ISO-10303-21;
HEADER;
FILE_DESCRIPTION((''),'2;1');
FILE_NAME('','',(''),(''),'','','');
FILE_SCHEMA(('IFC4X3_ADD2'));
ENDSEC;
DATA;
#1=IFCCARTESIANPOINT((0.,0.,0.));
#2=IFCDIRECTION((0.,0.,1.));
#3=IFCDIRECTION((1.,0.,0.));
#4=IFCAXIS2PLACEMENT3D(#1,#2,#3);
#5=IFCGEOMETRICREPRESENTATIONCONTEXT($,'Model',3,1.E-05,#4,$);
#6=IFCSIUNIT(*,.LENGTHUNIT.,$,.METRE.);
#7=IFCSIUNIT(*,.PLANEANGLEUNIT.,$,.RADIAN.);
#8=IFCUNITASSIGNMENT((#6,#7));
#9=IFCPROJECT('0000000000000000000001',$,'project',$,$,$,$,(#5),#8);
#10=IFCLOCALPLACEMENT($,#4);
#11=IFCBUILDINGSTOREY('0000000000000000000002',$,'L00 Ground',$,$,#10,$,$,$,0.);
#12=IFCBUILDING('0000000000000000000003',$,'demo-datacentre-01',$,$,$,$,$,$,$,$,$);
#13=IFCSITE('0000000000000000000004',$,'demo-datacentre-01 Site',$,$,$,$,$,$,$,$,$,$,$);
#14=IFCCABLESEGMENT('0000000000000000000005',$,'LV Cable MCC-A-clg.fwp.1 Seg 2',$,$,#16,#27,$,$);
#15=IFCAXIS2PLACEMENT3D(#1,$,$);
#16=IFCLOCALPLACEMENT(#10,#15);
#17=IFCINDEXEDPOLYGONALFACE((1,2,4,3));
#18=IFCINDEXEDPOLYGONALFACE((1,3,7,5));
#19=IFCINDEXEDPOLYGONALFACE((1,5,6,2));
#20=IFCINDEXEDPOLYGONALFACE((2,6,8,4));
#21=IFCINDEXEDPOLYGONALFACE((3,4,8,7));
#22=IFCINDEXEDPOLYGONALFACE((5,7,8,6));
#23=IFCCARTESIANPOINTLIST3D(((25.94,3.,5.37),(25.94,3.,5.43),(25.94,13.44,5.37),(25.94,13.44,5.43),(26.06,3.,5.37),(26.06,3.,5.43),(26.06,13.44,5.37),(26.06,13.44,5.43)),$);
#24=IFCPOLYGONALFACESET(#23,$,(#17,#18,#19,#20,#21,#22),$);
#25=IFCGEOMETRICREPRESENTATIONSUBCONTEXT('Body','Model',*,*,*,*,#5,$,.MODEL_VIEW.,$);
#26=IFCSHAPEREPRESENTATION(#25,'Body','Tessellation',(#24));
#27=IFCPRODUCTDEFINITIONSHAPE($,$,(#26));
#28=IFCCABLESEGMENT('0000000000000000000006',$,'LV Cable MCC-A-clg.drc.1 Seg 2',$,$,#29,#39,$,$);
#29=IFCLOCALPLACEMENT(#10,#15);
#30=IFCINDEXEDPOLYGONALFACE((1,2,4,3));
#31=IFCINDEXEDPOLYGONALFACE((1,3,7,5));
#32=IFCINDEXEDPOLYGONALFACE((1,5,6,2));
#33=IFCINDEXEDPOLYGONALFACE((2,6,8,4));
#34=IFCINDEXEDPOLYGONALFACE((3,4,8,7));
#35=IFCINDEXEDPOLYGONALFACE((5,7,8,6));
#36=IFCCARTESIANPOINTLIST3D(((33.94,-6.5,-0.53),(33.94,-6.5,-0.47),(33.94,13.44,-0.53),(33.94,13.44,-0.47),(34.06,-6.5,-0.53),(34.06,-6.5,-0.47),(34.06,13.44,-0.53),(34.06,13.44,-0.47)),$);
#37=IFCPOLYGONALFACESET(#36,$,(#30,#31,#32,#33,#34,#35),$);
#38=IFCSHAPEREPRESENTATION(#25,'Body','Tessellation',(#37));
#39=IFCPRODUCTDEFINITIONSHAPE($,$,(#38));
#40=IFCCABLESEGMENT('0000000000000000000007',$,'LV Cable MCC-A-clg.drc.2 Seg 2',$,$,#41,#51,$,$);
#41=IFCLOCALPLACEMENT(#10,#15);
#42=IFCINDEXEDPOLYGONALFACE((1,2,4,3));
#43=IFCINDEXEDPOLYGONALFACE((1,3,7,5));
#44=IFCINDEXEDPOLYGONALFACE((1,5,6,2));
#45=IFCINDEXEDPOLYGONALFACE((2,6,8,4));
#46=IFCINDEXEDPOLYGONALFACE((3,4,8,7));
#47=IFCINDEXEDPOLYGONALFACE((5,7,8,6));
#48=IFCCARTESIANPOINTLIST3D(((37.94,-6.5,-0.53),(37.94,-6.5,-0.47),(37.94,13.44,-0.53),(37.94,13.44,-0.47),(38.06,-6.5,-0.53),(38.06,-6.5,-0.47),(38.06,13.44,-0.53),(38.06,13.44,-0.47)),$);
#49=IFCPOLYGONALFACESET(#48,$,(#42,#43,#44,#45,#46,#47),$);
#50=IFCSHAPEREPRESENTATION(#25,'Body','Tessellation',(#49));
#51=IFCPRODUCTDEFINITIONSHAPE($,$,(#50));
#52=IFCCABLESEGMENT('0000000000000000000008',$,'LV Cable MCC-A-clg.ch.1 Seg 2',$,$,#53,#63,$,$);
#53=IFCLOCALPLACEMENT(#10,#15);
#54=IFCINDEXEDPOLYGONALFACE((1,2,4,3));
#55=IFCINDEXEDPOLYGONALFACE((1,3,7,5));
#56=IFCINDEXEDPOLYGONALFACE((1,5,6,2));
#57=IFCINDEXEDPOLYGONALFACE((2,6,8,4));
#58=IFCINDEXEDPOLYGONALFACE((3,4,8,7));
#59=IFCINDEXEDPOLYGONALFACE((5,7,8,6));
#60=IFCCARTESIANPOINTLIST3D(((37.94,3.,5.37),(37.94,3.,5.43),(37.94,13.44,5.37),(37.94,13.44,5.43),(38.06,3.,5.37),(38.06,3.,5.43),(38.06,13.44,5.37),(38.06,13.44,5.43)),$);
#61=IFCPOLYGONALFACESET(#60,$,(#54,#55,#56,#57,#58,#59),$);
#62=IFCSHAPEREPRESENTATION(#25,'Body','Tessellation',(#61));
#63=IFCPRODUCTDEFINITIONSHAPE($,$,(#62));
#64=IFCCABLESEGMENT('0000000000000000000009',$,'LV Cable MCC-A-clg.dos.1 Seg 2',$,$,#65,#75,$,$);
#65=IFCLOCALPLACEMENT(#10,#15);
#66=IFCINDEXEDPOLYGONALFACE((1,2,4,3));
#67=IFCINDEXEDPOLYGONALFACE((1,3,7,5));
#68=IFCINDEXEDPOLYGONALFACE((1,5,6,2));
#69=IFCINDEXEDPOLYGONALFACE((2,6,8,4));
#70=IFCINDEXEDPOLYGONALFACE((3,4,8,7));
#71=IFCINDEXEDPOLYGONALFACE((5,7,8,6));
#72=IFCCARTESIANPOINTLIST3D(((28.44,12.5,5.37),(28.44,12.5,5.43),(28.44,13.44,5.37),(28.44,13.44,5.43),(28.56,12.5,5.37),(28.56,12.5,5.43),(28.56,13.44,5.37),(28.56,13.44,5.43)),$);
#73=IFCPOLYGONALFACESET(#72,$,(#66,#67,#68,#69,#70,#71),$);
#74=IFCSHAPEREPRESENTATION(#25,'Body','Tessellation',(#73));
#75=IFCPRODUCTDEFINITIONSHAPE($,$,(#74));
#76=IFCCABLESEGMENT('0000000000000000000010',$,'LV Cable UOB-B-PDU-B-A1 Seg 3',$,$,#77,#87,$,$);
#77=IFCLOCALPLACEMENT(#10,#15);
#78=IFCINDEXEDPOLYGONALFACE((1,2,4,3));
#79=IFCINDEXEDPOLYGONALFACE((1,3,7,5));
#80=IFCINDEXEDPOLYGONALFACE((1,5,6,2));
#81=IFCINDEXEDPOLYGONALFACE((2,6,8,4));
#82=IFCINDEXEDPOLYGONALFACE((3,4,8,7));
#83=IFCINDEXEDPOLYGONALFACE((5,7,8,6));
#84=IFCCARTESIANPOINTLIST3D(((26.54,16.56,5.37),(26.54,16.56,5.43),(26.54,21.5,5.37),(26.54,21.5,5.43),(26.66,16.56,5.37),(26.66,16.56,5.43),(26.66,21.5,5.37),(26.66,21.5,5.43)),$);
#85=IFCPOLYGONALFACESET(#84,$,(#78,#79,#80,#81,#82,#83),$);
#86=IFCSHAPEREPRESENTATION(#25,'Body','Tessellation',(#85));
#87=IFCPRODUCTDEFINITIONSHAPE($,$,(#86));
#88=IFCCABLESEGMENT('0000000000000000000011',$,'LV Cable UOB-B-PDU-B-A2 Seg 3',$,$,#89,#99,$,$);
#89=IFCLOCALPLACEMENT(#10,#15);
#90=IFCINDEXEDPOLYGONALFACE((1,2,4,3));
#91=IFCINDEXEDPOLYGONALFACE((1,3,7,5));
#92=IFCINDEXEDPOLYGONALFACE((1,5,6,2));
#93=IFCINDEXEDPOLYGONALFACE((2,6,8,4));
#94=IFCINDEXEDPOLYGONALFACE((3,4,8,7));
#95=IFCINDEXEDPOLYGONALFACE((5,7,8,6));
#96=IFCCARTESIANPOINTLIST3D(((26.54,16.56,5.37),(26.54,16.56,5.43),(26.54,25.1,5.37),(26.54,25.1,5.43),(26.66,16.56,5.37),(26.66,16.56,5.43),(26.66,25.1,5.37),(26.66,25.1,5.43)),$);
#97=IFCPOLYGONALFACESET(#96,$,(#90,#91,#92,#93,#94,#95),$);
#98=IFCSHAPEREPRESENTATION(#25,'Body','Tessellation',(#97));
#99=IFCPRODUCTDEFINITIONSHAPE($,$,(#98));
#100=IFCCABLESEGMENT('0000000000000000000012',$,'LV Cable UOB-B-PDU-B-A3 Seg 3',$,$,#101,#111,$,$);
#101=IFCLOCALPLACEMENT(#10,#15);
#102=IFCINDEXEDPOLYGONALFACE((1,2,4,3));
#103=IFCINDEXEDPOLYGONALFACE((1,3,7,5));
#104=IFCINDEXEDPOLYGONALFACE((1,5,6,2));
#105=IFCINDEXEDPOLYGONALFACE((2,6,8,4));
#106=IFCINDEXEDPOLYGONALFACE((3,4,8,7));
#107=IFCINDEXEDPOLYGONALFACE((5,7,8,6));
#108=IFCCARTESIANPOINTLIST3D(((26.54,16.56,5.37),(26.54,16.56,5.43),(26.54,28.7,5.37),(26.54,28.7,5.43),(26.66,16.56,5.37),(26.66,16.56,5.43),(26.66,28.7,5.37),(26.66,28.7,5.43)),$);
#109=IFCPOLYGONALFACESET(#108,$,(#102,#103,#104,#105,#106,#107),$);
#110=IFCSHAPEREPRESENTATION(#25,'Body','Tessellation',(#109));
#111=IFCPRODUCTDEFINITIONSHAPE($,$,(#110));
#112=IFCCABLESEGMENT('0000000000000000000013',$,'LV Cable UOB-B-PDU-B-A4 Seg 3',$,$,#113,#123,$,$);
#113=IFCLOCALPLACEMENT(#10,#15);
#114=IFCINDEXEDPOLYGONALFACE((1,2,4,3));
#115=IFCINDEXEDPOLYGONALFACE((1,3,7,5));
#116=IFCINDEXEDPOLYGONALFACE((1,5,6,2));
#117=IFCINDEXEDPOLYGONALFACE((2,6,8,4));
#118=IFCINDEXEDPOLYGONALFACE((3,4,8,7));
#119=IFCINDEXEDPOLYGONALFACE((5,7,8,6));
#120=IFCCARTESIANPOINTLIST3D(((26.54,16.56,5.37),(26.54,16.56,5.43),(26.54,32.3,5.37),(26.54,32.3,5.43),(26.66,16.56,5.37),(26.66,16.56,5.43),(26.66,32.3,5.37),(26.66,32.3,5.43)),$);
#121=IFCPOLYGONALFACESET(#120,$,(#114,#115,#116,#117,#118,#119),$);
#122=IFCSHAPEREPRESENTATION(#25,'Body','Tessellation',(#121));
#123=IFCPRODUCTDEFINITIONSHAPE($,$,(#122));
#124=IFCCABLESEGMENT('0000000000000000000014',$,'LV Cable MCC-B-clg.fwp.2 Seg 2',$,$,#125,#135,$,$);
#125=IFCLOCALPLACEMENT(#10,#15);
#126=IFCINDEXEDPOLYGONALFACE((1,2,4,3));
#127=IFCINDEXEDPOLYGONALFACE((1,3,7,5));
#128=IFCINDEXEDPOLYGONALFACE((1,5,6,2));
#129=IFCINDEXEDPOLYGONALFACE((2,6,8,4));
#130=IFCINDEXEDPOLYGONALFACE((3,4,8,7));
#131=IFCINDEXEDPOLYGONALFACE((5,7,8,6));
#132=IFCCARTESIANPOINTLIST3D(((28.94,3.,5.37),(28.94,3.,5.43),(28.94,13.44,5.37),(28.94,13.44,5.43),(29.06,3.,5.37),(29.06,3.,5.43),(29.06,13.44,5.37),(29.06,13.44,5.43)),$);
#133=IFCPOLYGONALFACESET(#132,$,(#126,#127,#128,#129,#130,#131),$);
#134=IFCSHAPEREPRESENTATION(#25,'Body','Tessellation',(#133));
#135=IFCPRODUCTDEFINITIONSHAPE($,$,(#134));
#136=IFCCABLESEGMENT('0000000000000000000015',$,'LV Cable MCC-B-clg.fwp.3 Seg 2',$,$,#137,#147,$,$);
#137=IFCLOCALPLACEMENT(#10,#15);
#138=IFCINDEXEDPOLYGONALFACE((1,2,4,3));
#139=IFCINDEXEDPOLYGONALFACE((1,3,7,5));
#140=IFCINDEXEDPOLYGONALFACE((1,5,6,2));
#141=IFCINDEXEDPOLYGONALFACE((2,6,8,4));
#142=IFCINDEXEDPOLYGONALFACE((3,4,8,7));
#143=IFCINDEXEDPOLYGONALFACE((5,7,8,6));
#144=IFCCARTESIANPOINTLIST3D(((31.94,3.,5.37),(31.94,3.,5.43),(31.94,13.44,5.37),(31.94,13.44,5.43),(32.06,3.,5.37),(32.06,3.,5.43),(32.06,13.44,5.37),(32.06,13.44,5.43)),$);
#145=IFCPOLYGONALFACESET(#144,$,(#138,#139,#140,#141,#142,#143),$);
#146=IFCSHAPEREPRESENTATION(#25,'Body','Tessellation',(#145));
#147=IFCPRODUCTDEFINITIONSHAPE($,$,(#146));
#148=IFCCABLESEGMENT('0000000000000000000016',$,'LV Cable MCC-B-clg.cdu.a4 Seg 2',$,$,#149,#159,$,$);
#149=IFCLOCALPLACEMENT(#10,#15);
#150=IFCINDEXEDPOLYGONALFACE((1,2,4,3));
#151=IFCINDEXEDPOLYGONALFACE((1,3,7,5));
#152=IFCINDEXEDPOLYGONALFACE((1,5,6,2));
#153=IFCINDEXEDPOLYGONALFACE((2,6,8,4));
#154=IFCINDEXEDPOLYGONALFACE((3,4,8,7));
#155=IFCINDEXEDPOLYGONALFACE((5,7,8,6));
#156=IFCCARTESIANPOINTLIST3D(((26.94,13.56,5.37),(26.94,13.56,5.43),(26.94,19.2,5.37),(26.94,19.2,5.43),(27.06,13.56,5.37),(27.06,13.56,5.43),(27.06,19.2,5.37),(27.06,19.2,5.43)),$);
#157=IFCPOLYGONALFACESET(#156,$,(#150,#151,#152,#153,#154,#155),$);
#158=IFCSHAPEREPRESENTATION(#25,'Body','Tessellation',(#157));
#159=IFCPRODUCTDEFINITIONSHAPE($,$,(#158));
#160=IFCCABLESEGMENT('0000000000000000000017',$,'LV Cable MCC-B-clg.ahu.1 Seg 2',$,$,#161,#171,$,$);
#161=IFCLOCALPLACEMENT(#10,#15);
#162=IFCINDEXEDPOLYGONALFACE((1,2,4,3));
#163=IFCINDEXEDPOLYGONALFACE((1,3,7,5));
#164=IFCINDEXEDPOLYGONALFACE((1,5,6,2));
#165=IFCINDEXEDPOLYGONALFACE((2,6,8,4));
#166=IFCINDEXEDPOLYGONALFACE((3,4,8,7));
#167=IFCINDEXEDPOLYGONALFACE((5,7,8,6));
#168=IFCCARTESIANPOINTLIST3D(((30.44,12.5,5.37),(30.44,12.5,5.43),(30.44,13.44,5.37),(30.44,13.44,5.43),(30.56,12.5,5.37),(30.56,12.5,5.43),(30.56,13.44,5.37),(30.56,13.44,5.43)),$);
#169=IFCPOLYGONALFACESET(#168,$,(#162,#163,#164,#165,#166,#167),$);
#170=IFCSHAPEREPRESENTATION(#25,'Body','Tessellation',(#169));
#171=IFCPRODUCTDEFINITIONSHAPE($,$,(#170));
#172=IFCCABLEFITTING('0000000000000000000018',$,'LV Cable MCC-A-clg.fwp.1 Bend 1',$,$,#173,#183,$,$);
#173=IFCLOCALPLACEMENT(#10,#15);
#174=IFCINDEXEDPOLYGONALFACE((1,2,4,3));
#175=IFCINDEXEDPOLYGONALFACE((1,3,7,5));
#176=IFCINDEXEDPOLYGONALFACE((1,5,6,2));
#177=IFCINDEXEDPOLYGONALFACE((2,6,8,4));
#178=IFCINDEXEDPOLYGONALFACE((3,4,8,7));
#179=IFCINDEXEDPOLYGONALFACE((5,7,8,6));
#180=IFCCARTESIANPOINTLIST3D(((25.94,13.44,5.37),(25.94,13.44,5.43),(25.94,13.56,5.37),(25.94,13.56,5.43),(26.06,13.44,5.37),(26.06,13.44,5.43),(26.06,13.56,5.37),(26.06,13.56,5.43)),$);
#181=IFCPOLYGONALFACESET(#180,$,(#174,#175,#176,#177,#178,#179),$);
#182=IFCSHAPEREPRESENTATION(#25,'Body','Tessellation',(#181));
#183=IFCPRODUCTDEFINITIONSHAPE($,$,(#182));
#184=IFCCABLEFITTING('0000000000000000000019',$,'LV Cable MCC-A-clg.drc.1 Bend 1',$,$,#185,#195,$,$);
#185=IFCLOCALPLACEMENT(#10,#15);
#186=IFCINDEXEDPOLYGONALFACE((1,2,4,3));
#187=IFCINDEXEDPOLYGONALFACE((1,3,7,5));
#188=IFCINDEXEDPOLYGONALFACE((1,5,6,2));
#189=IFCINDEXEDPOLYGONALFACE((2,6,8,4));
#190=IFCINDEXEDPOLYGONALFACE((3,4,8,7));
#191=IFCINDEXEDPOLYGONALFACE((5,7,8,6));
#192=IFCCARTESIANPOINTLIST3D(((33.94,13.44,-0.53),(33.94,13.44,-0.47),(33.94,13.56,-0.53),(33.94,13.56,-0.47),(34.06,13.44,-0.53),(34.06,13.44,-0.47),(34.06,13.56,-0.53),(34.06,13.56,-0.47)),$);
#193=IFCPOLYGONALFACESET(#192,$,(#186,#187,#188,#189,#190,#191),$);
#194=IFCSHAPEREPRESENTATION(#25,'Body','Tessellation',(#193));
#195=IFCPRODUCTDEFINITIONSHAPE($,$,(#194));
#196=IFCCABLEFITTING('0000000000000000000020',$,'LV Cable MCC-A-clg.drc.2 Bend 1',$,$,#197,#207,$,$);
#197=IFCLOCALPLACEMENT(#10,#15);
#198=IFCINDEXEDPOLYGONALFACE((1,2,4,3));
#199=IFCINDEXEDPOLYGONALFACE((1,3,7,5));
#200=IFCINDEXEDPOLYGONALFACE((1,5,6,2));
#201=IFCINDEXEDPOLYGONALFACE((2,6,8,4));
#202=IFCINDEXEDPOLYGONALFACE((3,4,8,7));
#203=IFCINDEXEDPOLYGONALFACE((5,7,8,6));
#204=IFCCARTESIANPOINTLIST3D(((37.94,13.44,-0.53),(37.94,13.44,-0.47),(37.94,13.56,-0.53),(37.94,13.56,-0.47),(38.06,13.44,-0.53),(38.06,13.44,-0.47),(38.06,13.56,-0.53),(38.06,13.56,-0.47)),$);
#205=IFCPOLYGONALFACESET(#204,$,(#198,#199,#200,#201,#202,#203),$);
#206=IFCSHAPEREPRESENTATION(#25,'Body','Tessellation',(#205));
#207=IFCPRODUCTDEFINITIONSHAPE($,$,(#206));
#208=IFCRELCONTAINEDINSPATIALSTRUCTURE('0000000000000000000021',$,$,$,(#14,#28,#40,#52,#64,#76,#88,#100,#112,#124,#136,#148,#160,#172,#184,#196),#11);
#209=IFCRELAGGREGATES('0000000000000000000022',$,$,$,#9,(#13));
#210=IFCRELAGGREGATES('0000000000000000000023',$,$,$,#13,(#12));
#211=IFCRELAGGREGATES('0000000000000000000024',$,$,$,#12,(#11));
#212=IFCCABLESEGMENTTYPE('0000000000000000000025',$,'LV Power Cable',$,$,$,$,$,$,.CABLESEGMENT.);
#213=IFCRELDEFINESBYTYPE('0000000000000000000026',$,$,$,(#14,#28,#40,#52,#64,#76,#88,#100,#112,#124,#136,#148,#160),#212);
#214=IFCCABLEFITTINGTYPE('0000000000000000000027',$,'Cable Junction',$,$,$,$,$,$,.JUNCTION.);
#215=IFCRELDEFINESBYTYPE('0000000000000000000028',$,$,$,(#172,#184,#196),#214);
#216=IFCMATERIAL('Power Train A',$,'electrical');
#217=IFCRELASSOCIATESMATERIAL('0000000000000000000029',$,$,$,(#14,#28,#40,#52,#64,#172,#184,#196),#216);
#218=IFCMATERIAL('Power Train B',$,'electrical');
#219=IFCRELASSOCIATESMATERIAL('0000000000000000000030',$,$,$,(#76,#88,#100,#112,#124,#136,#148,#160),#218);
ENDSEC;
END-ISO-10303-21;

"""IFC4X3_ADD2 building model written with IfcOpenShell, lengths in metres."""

from ifc_helpers import new_model, si_unit, frame, origin_with_axes, place, context, subcontext, project, spatial, rectangle, extrude, material, type_object, element, save


model = new_model("IFC4X3_ADD2")

# Units and contexts
model_context = context("Model", 3, precision=1e-05, world=origin_with_axes())
body_context = subcontext(model_context, "Body", "Model", "MODEL_VIEW")
ifc_project = project(units=[si_unit("LENGTHUNIT", "METRE"), si_unit("PLANEANGLEUNIT", "RADIAN")], contexts=[model_context])

# Site, building, storey
site = spatial("IfcSite", under=ifc_project, Name="demo-datacentre-01 Site")
building = spatial("IfcBuilding", under=site, Name="demo-datacentre-01")
storey_placement = place(None, origin_with_axes())
storey = spatial("IfcBuildingStorey", under=building, at=storey_placement, Name="L00 Ground", Elevation=0.0)

# Shared definitions
ifc_material_1 = material(Name="Power Train B", Category="electrical")

# Cable segments
ifc_material_2 = material(Name="Power Train A", Category="electrical")
cable_segment_type_1 = type_object("IfcCableSegmentType", Name="LV Power Cable", PredefinedType="CABLESEGMENT")
cable_segment_1_placement = place(storey_placement, frame((26.0, 13.44, 5.4), z_axis=(0.0, -1.0, 0.0), x_axis=(1.0, 0.0, 0.0)))
element("IfcCableSegment", 1, at=cable_segment_1_placement, inside=storey, type_object=cable_segment_type_1, material=ifc_material_2, Name="LV Cable MCC-A-clg.fwp.1 Seg 2", context=body_context, shape_type="SweptSolid", body=[
    extrude(rectangle(XDim=0.12, YDim=0.06), origin_with_axes(), (0.0, 0.0, 1.0), 10.44),
])
for number, where, z_axis, x_axis, name in (
    (2, (34.0, 13.44, -0.5), (0.0, -1.0, 0.0), (1.0, 0.0, 0.0), "LV Cable MCC-A-clg.drc.1 Seg 2"),
    (3, (38.0, 13.44, -0.5), (0.0, -1.0, 0.0), (1.0, 0.0, 0.0), "LV Cable MCC-A-clg.drc.2 Seg 2"),
):
    element("IfcCableSegment", number, at=place(storey_placement, frame(where, z_axis=z_axis, x_axis=x_axis)), inside=storey, type_object=cable_segment_type_1, material=ifc_material_2, Name=name, context=body_context, shape_type="SweptSolid", body=[
        extrude(rectangle(XDim=0.12, YDim=0.06), origin_with_axes(), (0.0, 0.0, 1.0), 19.94),
    ])
cable_segment_2_placement = place(storey_placement, frame((38.0, 13.44, 5.4), z_axis=(0.0, -1.0, 0.0), x_axis=(1.0, 0.0, 0.0)))
element("IfcCableSegment", 4, at=cable_segment_2_placement, inside=storey, type_object=cable_segment_type_1, material=ifc_material_2, Name="LV Cable MCC-A-clg.ch.1 Seg 2", context=body_context, shape_type="SweptSolid", body=[
    extrude(rectangle(XDim=0.12, YDim=0.06), origin_with_axes(), (0.0, 0.0, 1.0), 10.44),
])
cable_segment_3_placement = place(storey_placement, frame((28.5, 13.44, 5.4), z_axis=(0.0, -1.0, 0.0), x_axis=(1.0, 0.0, 0.0)))
element("IfcCableSegment", 5, at=cable_segment_3_placement, inside=storey, type_object=cable_segment_type_1, material=ifc_material_2, Name="LV Cable MCC-A-clg.dos.1 Seg 2", context=body_context, shape_type="SweptSolid", body=[
    extrude(rectangle(XDim=0.12, YDim=0.06), origin_with_axes(), (0.0, 0.0, 1.0), 0.94),
])
cable_segment_4_placement = place(storey_placement, frame((26.6, 16.56, 5.4), z_axis=(0.0, 1.0, 0.0), x_axis=(-1.0, 0.0, 0.0)))
element("IfcCableSegment", 6, at=cable_segment_4_placement, inside=storey, type_object=cable_segment_type_1, material=ifc_material_1, Name="LV Cable UOB-B-PDU-B-A1 Seg 3", context=body_context, shape_type="SweptSolid", body=[
    extrude(rectangle(XDim=0.12, YDim=0.06), origin_with_axes(), (0.0, 0.0, 1.0), 4.94),
])
cable_segment_5_placement = place(storey_placement, frame((26.6, 16.56, 5.4), z_axis=(0.0, 1.0, 0.0), x_axis=(-1.0, 0.0, 0.0)))
element("IfcCableSegment", 7, at=cable_segment_5_placement, inside=storey, type_object=cable_segment_type_1, material=ifc_material_1, Name="LV Cable UOB-B-PDU-B-A2 Seg 3", context=body_context, shape_type="SweptSolid", body=[
    extrude(rectangle(XDim=0.12, YDim=0.06), origin_with_axes(), (0.0, 0.0, 1.0), 8.54),
])
cable_segment_6_placement = place(storey_placement, frame((26.6, 16.56, 5.4), z_axis=(0.0, 1.0, 0.0), x_axis=(-1.0, 0.0, 0.0)))
element("IfcCableSegment", 8, at=cable_segment_6_placement, inside=storey, type_object=cable_segment_type_1, material=ifc_material_1, Name="LV Cable UOB-B-PDU-B-A3 Seg 3", context=body_context, shape_type="SweptSolid", body=[
    extrude(rectangle(XDim=0.12, YDim=0.06), origin_with_axes(), (0.0, 0.0, 1.0), 12.14),
])
cable_segment_7_placement = place(storey_placement, frame((26.6, 16.56, 5.4), z_axis=(0.0, 1.0, 0.0), x_axis=(-1.0, 0.0, 0.0)))
element("IfcCableSegment", 9, at=cable_segment_7_placement, inside=storey, type_object=cable_segment_type_1, material=ifc_material_1, Name="LV Cable UOB-B-PDU-B-A4 Seg 3", context=body_context, shape_type="SweptSolid", body=[
    extrude(rectangle(XDim=0.12, YDim=0.06), origin_with_axes(), (0.0, 0.0, 1.0), 15.74),
])
for number, where, z_axis, x_axis, name in (
    (10, (29.0, 13.44, 5.4), (0.0, -1.0, 0.0), (1.0, 0.0, 0.0), "LV Cable MCC-B-clg.fwp.2 Seg 2"),
    (11, (32.0, 13.44, 5.4), (0.0, -1.0, 0.0), (1.0, 0.0, 0.0), "LV Cable MCC-B-clg.fwp.3 Seg 2"),
):
    element("IfcCableSegment", number, at=place(storey_placement, frame(where, z_axis=z_axis, x_axis=x_axis)), inside=storey, type_object=cable_segment_type_1, material=ifc_material_1, Name=name, context=body_context, shape_type="SweptSolid", body=[
        extrude(rectangle(XDim=0.12, YDim=0.06), origin_with_axes(), (0.0, 0.0, 1.0), 10.44),
    ])
cable_segment_8_placement = place(storey_placement, frame((27.0, 13.56, 5.4), z_axis=(0.0, 1.0, 0.0), x_axis=(-1.0, 0.0, 0.0)))
element("IfcCableSegment", 12, at=cable_segment_8_placement, inside=storey, type_object=cable_segment_type_1, material=ifc_material_1, Name="LV Cable MCC-B-clg.cdu.a4 Seg 2", context=body_context, shape_type="SweptSolid", body=[
    extrude(rectangle(XDim=0.12, YDim=0.06), origin_with_axes(), (0.0, 0.0, 1.0), 5.64),
])
cable_segment_9_placement = place(storey_placement, frame((30.5, 13.44, 5.4), z_axis=(0.0, -1.0, 0.0), x_axis=(1.0, 0.0, 0.0)))
element("IfcCableSegment", 13, at=cable_segment_9_placement, inside=storey, type_object=cable_segment_type_1, material=ifc_material_1, Name="LV Cable MCC-B-clg.ahu.1 Seg 2", context=body_context, shape_type="SweptSolid", body=[
    extrude(rectangle(XDim=0.12, YDim=0.06), origin_with_axes(), (0.0, 0.0, 1.0), 0.94),
])

# Cable fittings
cable_fitting_type_1 = type_object("IfcCableFittingType", Name="Cable Junction", PredefinedType="JUNCTION")
for number, where, z_axis, x_axis, name in (
    (14, (26.0, 13.5, 5.37), (0.0, 0.0, 1.0), (1.0, 0.0, 0.0), "LV Cable MCC-A-clg.fwp.1 Bend 1"),
    (15, (34.0, 13.5, -0.53), (0.0, 0.0, 1.0), (1.0, 0.0, 0.0), "LV Cable MCC-A-clg.drc.1 Bend 1"),
    (16, (38.0, 13.5, -0.53), (0.0, 0.0, 1.0), (1.0, 0.0, 0.0), "LV Cable MCC-A-clg.drc.2 Bend 1"),
):
    element("IfcCableFitting", number, at=place(storey_placement, frame(where, z_axis=z_axis, x_axis=x_axis)), inside=storey, type_object=cable_fitting_type_1, material=ifc_material_2, Name=name, context=body_context, shape_type="SweptSolid", body=[
        extrude(rectangle(XDim=0.12, YDim=0.12), origin_with_axes(), (0.0, 0.0, 1.0), 0.06),
    ])

save(model, "model.ifc")
